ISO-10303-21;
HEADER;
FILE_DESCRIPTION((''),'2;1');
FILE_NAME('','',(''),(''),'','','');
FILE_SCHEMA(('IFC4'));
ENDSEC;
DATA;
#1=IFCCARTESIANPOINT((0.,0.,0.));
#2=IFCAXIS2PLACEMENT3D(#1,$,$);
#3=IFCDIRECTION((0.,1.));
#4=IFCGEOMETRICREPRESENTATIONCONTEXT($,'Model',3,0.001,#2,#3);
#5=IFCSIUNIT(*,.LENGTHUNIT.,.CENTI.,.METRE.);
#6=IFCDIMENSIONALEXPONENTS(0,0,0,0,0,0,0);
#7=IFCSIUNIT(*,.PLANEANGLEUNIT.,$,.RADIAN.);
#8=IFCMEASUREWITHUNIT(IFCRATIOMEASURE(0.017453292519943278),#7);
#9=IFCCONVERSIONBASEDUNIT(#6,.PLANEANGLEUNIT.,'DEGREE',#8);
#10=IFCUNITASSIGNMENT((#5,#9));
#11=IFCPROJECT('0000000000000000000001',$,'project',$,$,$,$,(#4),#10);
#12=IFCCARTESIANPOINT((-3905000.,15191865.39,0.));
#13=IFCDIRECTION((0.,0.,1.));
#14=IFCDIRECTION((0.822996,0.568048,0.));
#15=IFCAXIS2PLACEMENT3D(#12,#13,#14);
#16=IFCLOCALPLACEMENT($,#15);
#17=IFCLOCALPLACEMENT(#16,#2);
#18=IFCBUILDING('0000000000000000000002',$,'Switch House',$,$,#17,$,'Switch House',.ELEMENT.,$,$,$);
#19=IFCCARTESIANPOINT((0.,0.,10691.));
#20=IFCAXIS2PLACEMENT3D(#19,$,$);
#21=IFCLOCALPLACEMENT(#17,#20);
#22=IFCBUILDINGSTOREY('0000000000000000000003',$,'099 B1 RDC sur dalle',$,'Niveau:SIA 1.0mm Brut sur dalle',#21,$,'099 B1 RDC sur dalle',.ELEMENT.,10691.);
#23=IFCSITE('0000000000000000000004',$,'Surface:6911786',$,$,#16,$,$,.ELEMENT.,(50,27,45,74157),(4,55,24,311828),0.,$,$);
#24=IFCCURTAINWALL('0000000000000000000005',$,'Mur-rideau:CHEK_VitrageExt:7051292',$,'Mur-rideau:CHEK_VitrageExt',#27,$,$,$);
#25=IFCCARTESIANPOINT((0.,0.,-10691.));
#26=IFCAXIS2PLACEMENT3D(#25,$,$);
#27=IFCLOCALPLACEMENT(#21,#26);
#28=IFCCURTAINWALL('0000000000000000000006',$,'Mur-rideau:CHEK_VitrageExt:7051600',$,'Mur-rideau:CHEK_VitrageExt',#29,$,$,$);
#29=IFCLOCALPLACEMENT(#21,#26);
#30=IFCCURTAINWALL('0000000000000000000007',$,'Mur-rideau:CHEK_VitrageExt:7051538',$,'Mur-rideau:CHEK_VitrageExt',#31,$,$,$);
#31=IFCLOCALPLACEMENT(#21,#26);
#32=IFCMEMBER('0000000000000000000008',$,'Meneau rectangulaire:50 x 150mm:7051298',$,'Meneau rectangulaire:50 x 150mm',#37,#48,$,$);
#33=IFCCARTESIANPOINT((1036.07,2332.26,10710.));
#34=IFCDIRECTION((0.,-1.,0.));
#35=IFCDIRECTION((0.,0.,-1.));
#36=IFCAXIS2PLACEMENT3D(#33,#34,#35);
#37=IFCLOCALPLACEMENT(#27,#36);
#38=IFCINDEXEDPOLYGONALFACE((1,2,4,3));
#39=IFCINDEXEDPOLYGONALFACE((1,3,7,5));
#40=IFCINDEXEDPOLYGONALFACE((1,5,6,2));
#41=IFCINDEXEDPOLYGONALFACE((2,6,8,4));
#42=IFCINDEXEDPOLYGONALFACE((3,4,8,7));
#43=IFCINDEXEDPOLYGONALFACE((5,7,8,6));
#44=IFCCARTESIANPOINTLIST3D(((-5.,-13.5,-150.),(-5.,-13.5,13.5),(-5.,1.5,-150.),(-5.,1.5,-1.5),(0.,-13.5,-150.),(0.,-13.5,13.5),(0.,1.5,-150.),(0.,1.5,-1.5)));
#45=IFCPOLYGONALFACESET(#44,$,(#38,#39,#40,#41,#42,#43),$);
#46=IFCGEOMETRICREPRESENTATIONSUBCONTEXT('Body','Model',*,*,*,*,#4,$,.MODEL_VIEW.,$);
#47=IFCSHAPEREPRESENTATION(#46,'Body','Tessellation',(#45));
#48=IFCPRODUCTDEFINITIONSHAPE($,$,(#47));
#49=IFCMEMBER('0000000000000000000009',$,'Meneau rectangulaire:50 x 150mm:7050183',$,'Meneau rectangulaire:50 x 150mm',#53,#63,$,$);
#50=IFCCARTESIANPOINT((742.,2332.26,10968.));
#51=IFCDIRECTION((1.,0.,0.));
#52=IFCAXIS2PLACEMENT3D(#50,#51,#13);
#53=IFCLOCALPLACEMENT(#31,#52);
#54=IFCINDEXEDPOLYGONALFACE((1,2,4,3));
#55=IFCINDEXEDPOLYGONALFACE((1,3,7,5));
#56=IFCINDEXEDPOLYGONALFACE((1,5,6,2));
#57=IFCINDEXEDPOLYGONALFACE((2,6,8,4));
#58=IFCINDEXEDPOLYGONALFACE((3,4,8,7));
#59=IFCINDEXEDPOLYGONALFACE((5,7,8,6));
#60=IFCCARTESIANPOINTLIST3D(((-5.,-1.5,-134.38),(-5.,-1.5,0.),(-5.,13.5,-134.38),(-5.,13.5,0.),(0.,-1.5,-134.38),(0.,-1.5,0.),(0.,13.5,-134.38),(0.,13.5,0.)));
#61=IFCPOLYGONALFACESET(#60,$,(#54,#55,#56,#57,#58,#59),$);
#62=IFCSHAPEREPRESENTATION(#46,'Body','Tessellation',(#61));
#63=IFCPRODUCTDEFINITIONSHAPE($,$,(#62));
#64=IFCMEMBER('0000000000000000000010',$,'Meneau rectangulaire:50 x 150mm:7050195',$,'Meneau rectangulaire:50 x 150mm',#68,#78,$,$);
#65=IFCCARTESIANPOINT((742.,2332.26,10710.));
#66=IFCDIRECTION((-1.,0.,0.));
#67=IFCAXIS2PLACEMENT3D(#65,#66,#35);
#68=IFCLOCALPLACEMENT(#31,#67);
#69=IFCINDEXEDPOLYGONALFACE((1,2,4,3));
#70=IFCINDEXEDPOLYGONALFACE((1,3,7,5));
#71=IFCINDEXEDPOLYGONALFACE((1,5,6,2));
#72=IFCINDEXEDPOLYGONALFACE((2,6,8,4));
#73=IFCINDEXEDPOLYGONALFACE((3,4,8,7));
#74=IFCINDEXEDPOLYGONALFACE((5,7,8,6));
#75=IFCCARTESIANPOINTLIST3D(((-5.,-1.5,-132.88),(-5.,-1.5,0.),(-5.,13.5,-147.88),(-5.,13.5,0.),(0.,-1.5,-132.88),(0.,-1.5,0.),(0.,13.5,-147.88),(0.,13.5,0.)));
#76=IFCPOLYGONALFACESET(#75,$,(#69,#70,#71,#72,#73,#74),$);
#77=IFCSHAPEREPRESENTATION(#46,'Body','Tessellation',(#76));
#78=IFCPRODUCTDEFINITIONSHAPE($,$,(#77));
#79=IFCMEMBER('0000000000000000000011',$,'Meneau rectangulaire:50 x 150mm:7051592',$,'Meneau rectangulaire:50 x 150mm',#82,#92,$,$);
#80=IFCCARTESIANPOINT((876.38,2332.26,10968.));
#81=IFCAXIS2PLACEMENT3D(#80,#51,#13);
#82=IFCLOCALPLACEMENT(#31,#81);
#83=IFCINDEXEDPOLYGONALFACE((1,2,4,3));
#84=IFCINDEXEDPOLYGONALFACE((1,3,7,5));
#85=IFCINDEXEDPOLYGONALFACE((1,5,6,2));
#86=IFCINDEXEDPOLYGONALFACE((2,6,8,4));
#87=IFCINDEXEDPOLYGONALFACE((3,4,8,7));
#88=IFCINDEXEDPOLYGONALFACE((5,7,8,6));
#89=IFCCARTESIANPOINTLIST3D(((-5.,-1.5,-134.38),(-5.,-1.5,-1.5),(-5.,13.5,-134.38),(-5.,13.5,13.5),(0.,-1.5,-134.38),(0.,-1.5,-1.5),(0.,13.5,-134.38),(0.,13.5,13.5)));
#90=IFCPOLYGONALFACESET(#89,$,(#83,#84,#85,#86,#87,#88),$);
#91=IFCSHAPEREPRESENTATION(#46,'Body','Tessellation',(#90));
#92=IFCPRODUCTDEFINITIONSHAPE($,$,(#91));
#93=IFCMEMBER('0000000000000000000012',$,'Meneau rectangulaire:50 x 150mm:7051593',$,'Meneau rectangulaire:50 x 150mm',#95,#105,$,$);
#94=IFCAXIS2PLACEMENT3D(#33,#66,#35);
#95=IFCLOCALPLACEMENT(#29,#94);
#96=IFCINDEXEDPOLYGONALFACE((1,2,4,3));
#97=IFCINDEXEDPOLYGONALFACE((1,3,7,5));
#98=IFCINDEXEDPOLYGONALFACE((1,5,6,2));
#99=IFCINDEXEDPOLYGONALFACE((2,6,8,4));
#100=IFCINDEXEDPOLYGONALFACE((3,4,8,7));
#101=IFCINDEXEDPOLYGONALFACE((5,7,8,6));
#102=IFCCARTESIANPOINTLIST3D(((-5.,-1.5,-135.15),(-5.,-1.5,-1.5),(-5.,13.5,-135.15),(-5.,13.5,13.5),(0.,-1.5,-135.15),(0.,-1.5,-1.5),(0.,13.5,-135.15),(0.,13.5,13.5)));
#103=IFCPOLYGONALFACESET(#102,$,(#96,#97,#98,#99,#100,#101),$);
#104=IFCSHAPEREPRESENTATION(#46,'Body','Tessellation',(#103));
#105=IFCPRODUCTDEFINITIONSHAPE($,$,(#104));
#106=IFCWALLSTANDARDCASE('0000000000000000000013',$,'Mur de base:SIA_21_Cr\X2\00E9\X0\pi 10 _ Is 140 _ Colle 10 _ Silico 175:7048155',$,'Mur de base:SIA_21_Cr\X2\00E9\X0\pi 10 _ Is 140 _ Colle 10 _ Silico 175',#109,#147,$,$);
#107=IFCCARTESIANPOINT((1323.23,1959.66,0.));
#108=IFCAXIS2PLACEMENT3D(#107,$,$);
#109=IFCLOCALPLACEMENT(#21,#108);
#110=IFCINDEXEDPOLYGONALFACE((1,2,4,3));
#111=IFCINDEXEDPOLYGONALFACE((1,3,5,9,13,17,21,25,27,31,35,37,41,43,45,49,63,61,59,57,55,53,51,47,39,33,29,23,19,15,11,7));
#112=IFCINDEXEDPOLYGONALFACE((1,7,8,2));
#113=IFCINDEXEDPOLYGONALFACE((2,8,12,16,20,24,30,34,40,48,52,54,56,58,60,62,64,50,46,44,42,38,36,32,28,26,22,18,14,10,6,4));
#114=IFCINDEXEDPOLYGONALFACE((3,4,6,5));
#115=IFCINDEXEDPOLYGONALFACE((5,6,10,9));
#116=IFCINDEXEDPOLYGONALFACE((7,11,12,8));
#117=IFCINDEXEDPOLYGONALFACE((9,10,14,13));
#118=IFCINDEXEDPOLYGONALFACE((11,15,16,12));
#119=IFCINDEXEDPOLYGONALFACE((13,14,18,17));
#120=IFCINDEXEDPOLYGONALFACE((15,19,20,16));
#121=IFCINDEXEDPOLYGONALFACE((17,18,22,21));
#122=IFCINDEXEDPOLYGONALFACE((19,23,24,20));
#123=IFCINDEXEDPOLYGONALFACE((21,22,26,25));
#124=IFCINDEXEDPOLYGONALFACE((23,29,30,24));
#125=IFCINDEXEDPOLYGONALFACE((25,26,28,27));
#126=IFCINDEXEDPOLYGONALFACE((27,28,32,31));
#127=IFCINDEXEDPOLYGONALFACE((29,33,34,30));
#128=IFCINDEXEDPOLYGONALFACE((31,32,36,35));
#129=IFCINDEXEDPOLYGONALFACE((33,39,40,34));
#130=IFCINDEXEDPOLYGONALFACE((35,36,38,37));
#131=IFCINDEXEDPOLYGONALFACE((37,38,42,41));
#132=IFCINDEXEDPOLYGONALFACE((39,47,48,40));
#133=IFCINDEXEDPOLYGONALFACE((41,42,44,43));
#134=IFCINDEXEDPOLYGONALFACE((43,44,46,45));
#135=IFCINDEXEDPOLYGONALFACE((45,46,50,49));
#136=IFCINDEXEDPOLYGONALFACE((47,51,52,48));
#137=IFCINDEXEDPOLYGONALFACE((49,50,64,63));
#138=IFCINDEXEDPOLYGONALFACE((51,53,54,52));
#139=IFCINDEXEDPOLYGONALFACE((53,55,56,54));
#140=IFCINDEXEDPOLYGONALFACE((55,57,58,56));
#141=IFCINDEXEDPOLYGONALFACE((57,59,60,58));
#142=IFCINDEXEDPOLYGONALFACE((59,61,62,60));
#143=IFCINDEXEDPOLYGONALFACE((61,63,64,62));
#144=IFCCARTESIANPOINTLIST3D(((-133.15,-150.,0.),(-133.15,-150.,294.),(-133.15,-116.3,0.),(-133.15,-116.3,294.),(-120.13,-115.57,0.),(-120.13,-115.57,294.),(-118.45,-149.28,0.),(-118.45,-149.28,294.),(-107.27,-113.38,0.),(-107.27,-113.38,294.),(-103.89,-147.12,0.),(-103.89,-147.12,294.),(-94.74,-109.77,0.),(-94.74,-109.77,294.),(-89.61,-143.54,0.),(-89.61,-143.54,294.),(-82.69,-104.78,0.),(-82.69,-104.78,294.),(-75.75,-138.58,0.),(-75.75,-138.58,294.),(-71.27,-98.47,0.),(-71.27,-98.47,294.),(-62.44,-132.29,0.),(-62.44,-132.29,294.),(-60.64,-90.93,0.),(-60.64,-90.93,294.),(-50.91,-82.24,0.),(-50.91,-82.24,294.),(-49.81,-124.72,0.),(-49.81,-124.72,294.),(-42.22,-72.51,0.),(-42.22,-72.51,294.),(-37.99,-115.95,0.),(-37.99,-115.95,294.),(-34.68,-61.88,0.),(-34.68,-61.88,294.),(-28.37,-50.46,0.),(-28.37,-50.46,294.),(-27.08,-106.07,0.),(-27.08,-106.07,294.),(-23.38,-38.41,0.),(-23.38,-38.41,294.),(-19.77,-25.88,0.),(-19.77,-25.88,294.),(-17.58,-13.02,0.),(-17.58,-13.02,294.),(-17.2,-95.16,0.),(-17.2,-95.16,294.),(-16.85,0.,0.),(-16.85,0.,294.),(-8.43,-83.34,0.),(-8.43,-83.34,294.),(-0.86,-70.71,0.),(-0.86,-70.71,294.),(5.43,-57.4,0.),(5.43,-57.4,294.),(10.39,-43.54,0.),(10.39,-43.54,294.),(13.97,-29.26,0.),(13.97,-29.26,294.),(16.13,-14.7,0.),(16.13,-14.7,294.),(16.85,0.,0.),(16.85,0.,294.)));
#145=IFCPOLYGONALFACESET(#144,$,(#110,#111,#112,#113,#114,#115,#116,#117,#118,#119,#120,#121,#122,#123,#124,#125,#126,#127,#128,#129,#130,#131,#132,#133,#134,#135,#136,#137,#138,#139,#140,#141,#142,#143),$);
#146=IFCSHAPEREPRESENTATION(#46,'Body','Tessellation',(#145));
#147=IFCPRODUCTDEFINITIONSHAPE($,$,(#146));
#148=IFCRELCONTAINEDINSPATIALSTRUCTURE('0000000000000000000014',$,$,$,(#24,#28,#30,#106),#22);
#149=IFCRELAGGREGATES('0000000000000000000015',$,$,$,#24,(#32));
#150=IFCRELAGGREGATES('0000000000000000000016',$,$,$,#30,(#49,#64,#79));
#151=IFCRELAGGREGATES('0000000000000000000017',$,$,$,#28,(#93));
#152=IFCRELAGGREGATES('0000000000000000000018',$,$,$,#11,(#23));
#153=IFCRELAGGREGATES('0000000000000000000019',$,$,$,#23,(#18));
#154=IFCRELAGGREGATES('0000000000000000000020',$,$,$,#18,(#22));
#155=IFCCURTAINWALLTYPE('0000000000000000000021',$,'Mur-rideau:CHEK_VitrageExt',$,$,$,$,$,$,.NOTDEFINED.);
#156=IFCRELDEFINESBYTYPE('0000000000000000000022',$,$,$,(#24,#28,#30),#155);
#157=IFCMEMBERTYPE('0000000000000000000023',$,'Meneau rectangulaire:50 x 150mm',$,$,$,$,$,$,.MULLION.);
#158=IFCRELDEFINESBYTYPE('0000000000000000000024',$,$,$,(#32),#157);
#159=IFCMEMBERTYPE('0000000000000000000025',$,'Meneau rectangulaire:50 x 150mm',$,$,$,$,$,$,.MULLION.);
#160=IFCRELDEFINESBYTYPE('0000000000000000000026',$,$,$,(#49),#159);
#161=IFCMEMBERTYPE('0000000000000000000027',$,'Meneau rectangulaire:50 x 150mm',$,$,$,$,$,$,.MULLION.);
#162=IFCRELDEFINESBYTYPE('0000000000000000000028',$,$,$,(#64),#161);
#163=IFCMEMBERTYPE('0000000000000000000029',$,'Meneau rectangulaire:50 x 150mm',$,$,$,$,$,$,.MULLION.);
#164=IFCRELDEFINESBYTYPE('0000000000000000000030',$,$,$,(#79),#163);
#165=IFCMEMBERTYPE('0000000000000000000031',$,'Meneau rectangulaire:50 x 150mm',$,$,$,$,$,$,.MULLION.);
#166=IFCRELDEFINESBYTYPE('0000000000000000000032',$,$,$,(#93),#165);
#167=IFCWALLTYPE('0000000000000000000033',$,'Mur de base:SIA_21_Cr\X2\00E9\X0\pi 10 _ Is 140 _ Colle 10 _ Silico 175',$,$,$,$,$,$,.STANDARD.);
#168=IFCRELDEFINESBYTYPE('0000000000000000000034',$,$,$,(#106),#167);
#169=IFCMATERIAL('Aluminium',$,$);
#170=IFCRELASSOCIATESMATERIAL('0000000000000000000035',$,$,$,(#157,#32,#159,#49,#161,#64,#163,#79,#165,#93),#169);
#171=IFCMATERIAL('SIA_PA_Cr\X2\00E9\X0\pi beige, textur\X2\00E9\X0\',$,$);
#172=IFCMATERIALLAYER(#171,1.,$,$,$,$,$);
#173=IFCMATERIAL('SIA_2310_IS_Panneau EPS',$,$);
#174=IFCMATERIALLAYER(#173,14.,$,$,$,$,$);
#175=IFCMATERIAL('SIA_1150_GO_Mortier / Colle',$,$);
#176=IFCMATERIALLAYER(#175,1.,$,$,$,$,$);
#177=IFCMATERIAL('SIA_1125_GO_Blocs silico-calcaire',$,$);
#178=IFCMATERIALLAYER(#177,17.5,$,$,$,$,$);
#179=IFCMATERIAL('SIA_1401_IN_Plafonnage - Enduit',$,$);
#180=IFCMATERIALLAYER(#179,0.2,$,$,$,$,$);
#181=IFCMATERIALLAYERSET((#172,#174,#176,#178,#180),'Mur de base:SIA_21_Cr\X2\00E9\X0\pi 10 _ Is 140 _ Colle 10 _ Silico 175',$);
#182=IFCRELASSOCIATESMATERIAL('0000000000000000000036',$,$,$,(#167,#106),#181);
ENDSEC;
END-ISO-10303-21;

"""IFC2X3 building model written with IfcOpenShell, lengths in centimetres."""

from ifc_helpers import new_model, entity, si_unit, converted_unit, direction, frame, frame_2d, origin, origin_2d_with_axis, place, context, subcontext, project, spatial, polyline, circle_curve, parameter, trimmed, segment, composite_curve, rectangle, outline, extrude, clip, halfspace, source, transform, mapped, material, layer, layer_set, layer_usage, type_object, type_shapes, element, aggregate, save


model = new_model("IFC2X3")

# Units and contexts
model_context = context("Model", 3, precision=0.001, world=origin(), true_north=direction((0.0, 1.0)))
body_context = subcontext(model_context, "Body", "Model", "MODEL_VIEW")
ifc_project = project(units=[si_unit("LENGTHUNIT", "METRE", prefix="CENTI"), converted_unit("PLANEANGLEUNIT", "DEGREE", entity("IfcRatioMeasure", 0.017453292519943278), si_unit("PLANEANGLEUNIT", "RADIAN"), dimensions=[0, 0, 0, 0, 0, 0, 0])], contexts=[model_context])

# Site, building, storey
site_placement = place(None, frame((-3905000.0, 15191865.39, 0.0), z_axis=(0.0, 0.0, 1.0), x_axis=(0.822996, 0.568048, 0.0)))
site = spatial("IfcSite", under=ifc_project, at=site_placement, Name="Surface:6911786", CompositionType="ELEMENT", RefLatitude=(50, 27, 45, 74157), RefLongitude=(4, 55, 24, 311828), RefElevation=0.0)
building_placement = place(site_placement, origin())
building = spatial("IfcBuilding", under=site, at=building_placement, Name="Switch House", LongName="Switch House", CompositionType="ELEMENT")
storey_placement = place(building_placement, frame((0.0, 0.0, 10691.0)))
storey = spatial("IfcBuildingStorey", under=building, at=storey_placement, Name="099 B1 RDC sur dalle", ObjectType="Niveau:SIA 1.0mm Brut sur dalle", LongName="099 B1 RDC sur dalle", CompositionType="ELEMENT", Elevation=10691.0)

# Curtain walls
curtain_wall_type = type_object("IfcCurtainWallType", Name="Mur-rideau:CHEK_VitrageExt", PredefinedType="NOTDEFINED")
curtain_wall_1_placement = place(storey_placement, frame((0.0, 0.0, -10691.0)))
curtain_wall_1 = element("IfcCurtainWall", 1, at=curtain_wall_1_placement, inside=storey, type_object=curtain_wall_type, Name="Mur-rideau:CHEK_VitrageExt:7051292", ObjectType="Mur-rideau:CHEK_VitrageExt")
ifc_material_1 = material(Name="Aluminium")
curtain_wall_2_placement = place(storey_placement, frame((0.0, 0.0, -10691.0)))
curtain_wall_2 = element("IfcCurtainWall", 2, at=curtain_wall_2_placement, inside=storey, type_object=curtain_wall_type, Name="Mur-rideau:CHEK_VitrageExt:7051600", ObjectType="Mur-rideau:CHEK_VitrageExt")

# Curtain wall
curtain_wall_3_placement = place(storey_placement, frame((0.0, 0.0, -10691.0)))
curtain_wall_3 = element("IfcCurtainWall", 3, at=curtain_wall_3_placement, inside=storey, type_object=curtain_wall_type, Name="Mur-rideau:CHEK_VitrageExt:7051538", ObjectType="Mur-rideau:CHEK_VitrageExt")

# Members
member_type_1 = type_object("IfcMemberType", Name="Meneau rectangulaire:50 x 150mm", PredefinedType="MULLION", material=ifc_material_1)
shared_shape_1 = source(origin(), body_context, "Body", "SweptSolid", [
    clip(extrude(rectangle(XDim=15.0, YDim=5.0, at=origin_2d_with_axis()), frame((-2.5, -6.0, -150.0), z_axis=(0.0, 0.0, 1.0), x_axis=(0.0, -1.0, 0.0)), (0.0, 0.0, 1.0), 163.5), halfspace(frame((-30.48, 0.0, 0.0), z_axis=(0.0, 0.707107, 0.707107), x_axis=(0.0, 0.707107, -0.707107)), False)),
])
type_shapes(member_type_1, [shared_shape_1])
member_1_placement = place(curtain_wall_1_placement, frame((1036.07, 2332.26, 10710.0), z_axis=(0.0, -1.0, 0.0), x_axis=(0.0, 0.0, -1.0)))
member_1 = element("IfcMember", 4, at=member_1_placement, type_object=member_type_1, material=ifc_material_1, Name="Meneau rectangulaire:50 x 150mm:7051298", ObjectType="Meneau rectangulaire:50 x 150mm", context=body_context, shape_type="MappedRepresentation", body=[
    mapped(shared_shape_1, transform((0.0, 0.0, 0.0), scale=1.0)),
])
member_type_2 = type_object("IfcMemberType", Name="Meneau rectangulaire:50 x 150mm", PredefinedType="MULLION", material=ifc_material_1)
shared_shape_2 = source(origin(), body_context, "Body", "SweptSolid", [
    extrude(rectangle(XDim=15.0, YDim=5.0, at=origin_2d_with_axis()), frame((-2.5, 6.0, -134.38), z_axis=(0.0, 0.0, 1.0), x_axis=(0.0, -1.0, 0.0)), (0.0, 0.0, 1.0), 134.38),
])
type_shapes(member_type_2, [shared_shape_2])
member_2_placement = place(curtain_wall_3_placement, frame((742.0, 2332.26, 10968.0), z_axis=(1.0, 0.0, 0.0), x_axis=(0.0, 0.0, 1.0)))
member_2 = element("IfcMember", 5, at=member_2_placement, type_object=member_type_2, material=ifc_material_1, Name="Meneau rectangulaire:50 x 150mm:7050183", ObjectType="Meneau rectangulaire:50 x 150mm", context=body_context, shape_type="MappedRepresentation", body=[
    mapped(shared_shape_2, transform((0.0, 0.0, 0.0), scale=1.0)),
])
member_type_3 = type_object("IfcMemberType", Name="Meneau rectangulaire:50 x 150mm", PredefinedType="MULLION", material=ifc_material_1)
shared_shape_3 = source(origin(), body_context, "Body", "SweptSolid", [
    clip(extrude(rectangle(XDim=15.0, YDim=5.0, at=origin_2d_with_axis()), frame((-2.5, 6.0, -147.88), z_axis=(0.0, 0.0, 1.0), x_axis=(0.0, -1.0, 0.0)), (0.0, 0.0, 1.0), 147.88), halfspace(frame((30.48, 0.0, -134.38), z_axis=(0.0, -0.707107, -0.707107), x_axis=(0.0, -0.707107, 0.707107)), False)),
])
type_shapes(member_type_3, [shared_shape_3])
member_3_placement = place(curtain_wall_3_placement, frame((742.0, 2332.26, 10710.0), z_axis=(-1.0, 0.0, 0.0), x_axis=(0.0, 0.0, -1.0)))
member_3 = element("IfcMember", 6, at=member_3_placement, type_object=member_type_3, material=ifc_material_1, Name="Meneau rectangulaire:50 x 150mm:7050195", ObjectType="Meneau rectangulaire:50 x 150mm", context=body_context, shape_type="MappedRepresentation", body=[
    mapped(shared_shape_3, transform((0.0, 0.0, 0.0), scale=1.0)),
])
member_type_4 = type_object("IfcMemberType", Name="Meneau rectangulaire:50 x 150mm", PredefinedType="MULLION", material=ifc_material_1)
shared_shape_4 = source(origin(), body_context, "Body", "SweptSolid", [
    clip(extrude(rectangle(XDim=15.0, YDim=5.0, at=origin_2d_with_axis()), frame((-2.5, 6.0, -134.38), z_axis=(0.0, 0.0, 1.0), x_axis=(0.0, -1.0, 0.0)), (0.0, 0.0, 1.0), 147.88), halfspace(frame((30.48, 0.0, 0.0), z_axis=(0.0, -0.707107, 0.707107), x_axis=(0.0, -0.707107, -0.707107)), False)),
])
type_shapes(member_type_4, [shared_shape_4])
member_4_placement = place(curtain_wall_3_placement, frame((876.38, 2332.26, 10968.0), z_axis=(1.0, 0.0, 0.0), x_axis=(0.0, 0.0, 1.0)))
member_4 = element("IfcMember", 7, at=member_4_placement, type_object=member_type_4, material=ifc_material_1, Name="Meneau rectangulaire:50 x 150mm:7051592", ObjectType="Meneau rectangulaire:50 x 150mm", context=body_context, shape_type="MappedRepresentation", body=[
    mapped(shared_shape_4, transform((0.0, 0.0, 0.0), scale=1.0)),
])
member_type_5 = type_object("IfcMemberType", Name="Meneau rectangulaire:50 x 150mm", PredefinedType="MULLION", material=ifc_material_1)
shared_shape_5 = source(origin(), body_context, "Body", "SweptSolid", [
    clip(extrude(rectangle(XDim=15.0, YDim=5.0, at=origin_2d_with_axis()), frame((-2.5, 6.0, -135.15), z_axis=(0.0, 0.0, 1.0), x_axis=(0.0, -1.0, 0.0)), (0.0, 0.0, 1.0), 148.65), halfspace(frame((30.48, 0.0, 0.0), z_axis=(0.0, -0.707107, 0.707107), x_axis=(0.0, -0.707107, -0.707107)), False)),
])
type_shapes(member_type_5, [shared_shape_5])
member_5_placement = place(curtain_wall_2_placement, frame((1036.07, 2332.26, 10710.0), z_axis=(-1.0, 0.0, 0.0), x_axis=(0.0, 0.0, -1.0)))
member_5 = element("IfcMember", 8, at=member_5_placement, type_object=member_type_5, material=ifc_material_1, Name="Meneau rectangulaire:50 x 150mm:7051593", ObjectType="Meneau rectangulaire:50 x 150mm", context=body_context, shape_type="MappedRepresentation", body=[
    mapped(shared_shape_5, transform((0.0, 0.0, 0.0), scale=1.0)),
])

aggregate(curtain_wall_1, [member_1])
aggregate(curtain_wall_3, [member_2, member_3, member_4])
aggregate(curtain_wall_2, [member_5])

# Wall
ifc_material_2 = material(Name="SIA_PA_Crépi beige, texturé")
ifc_layer_1 = layer(ifc_material_2, 1.0)
ifc_material_3 = material(Name="SIA_2310_IS_Panneau EPS")
ifc_layer_2 = layer(ifc_material_3, 14.0)
ifc_material_4 = material(Name="SIA_1150_GO_Mortier / Colle")
ifc_layer_3 = layer(ifc_material_4, 1.0)
ifc_material_5 = material(Name="SIA_1125_GO_Blocs silico-calcaire")
ifc_layer_4 = layer(ifc_material_5, 17.5)
ifc_material_6 = material(Name="SIA_1401_IN_Plafonnage - Enduit")
ifc_layer_5 = layer(ifc_material_6, 0.2)
ifc_layer_set_1 = layer_set([ifc_layer_1, ifc_layer_2, ifc_layer_3, ifc_layer_4, ifc_layer_5], Name="Mur de base:SIA_21_Crépi 10 _ Is 140 _ Colle 10 _ Silico 175")
ifc_layer_usage_1 = layer_usage(ifc_layer_set_1, "AXIS2", "POSITIVE", -16.85)
wall_type_1 = type_object("IfcWallType", Name="Mur de base:SIA_21_Crépi 10 _ Is 140 _ Colle 10 _ Silico 175", PredefinedType="STANDARD", material=ifc_layer_set_1)
wall_1_placement = place(storey_placement, frame((1323.23, 1959.66, 0.0)))
element("IfcWallStandardCase", 9, at=wall_1_placement, inside=storey, type_object=wall_type_1, material=ifc_layer_usage_1, Name="Mur de base:SIA_21_Crépi 10 _ Is 140 _ Colle 10 _ Silico 175:7048155", ObjectType="Mur de base:SIA_21_Crépi 10 _ Is 140 _ Colle 10 _ Silico 175", context=body_context, shape_type="Clipping", body=[
    clip(extrude(outline(composite_curve([segment(trimmed(circle_curve(frame_2d((-133.15, 0.0), x_axis=(1.0, 0.0)), 150.0), [parameter(270.0)], [parameter(0.0)], True, "PARAMETER"), True, "CONTINUOUS"), segment(polyline([(16.85, 0.0), (-16.85, 0.0)]), True, "CONTINUOUS"), segment(trimmed(circle_curve(frame_2d((-133.15, 0.0), x_axis=(1.0, 0.0)), 116.3), [parameter(270.0)], [parameter(0.0)], True, "PARAMETER"), False, "CONTINUOUS"), segment(polyline([(-133.15, -116.3), (-133.15, -150.0)]), True, "CONTINUOUS")], self_intersect=False)), origin(), (0.0, 0.0, 1.0), 294.0), halfspace(frame((-133.15, -150.0, 294.0), z_axis=(0.0, 0.0, -1.0), x_axis=(0.0, -1.0, 0.0)), True)),
])

save(model, "model.ifc")
